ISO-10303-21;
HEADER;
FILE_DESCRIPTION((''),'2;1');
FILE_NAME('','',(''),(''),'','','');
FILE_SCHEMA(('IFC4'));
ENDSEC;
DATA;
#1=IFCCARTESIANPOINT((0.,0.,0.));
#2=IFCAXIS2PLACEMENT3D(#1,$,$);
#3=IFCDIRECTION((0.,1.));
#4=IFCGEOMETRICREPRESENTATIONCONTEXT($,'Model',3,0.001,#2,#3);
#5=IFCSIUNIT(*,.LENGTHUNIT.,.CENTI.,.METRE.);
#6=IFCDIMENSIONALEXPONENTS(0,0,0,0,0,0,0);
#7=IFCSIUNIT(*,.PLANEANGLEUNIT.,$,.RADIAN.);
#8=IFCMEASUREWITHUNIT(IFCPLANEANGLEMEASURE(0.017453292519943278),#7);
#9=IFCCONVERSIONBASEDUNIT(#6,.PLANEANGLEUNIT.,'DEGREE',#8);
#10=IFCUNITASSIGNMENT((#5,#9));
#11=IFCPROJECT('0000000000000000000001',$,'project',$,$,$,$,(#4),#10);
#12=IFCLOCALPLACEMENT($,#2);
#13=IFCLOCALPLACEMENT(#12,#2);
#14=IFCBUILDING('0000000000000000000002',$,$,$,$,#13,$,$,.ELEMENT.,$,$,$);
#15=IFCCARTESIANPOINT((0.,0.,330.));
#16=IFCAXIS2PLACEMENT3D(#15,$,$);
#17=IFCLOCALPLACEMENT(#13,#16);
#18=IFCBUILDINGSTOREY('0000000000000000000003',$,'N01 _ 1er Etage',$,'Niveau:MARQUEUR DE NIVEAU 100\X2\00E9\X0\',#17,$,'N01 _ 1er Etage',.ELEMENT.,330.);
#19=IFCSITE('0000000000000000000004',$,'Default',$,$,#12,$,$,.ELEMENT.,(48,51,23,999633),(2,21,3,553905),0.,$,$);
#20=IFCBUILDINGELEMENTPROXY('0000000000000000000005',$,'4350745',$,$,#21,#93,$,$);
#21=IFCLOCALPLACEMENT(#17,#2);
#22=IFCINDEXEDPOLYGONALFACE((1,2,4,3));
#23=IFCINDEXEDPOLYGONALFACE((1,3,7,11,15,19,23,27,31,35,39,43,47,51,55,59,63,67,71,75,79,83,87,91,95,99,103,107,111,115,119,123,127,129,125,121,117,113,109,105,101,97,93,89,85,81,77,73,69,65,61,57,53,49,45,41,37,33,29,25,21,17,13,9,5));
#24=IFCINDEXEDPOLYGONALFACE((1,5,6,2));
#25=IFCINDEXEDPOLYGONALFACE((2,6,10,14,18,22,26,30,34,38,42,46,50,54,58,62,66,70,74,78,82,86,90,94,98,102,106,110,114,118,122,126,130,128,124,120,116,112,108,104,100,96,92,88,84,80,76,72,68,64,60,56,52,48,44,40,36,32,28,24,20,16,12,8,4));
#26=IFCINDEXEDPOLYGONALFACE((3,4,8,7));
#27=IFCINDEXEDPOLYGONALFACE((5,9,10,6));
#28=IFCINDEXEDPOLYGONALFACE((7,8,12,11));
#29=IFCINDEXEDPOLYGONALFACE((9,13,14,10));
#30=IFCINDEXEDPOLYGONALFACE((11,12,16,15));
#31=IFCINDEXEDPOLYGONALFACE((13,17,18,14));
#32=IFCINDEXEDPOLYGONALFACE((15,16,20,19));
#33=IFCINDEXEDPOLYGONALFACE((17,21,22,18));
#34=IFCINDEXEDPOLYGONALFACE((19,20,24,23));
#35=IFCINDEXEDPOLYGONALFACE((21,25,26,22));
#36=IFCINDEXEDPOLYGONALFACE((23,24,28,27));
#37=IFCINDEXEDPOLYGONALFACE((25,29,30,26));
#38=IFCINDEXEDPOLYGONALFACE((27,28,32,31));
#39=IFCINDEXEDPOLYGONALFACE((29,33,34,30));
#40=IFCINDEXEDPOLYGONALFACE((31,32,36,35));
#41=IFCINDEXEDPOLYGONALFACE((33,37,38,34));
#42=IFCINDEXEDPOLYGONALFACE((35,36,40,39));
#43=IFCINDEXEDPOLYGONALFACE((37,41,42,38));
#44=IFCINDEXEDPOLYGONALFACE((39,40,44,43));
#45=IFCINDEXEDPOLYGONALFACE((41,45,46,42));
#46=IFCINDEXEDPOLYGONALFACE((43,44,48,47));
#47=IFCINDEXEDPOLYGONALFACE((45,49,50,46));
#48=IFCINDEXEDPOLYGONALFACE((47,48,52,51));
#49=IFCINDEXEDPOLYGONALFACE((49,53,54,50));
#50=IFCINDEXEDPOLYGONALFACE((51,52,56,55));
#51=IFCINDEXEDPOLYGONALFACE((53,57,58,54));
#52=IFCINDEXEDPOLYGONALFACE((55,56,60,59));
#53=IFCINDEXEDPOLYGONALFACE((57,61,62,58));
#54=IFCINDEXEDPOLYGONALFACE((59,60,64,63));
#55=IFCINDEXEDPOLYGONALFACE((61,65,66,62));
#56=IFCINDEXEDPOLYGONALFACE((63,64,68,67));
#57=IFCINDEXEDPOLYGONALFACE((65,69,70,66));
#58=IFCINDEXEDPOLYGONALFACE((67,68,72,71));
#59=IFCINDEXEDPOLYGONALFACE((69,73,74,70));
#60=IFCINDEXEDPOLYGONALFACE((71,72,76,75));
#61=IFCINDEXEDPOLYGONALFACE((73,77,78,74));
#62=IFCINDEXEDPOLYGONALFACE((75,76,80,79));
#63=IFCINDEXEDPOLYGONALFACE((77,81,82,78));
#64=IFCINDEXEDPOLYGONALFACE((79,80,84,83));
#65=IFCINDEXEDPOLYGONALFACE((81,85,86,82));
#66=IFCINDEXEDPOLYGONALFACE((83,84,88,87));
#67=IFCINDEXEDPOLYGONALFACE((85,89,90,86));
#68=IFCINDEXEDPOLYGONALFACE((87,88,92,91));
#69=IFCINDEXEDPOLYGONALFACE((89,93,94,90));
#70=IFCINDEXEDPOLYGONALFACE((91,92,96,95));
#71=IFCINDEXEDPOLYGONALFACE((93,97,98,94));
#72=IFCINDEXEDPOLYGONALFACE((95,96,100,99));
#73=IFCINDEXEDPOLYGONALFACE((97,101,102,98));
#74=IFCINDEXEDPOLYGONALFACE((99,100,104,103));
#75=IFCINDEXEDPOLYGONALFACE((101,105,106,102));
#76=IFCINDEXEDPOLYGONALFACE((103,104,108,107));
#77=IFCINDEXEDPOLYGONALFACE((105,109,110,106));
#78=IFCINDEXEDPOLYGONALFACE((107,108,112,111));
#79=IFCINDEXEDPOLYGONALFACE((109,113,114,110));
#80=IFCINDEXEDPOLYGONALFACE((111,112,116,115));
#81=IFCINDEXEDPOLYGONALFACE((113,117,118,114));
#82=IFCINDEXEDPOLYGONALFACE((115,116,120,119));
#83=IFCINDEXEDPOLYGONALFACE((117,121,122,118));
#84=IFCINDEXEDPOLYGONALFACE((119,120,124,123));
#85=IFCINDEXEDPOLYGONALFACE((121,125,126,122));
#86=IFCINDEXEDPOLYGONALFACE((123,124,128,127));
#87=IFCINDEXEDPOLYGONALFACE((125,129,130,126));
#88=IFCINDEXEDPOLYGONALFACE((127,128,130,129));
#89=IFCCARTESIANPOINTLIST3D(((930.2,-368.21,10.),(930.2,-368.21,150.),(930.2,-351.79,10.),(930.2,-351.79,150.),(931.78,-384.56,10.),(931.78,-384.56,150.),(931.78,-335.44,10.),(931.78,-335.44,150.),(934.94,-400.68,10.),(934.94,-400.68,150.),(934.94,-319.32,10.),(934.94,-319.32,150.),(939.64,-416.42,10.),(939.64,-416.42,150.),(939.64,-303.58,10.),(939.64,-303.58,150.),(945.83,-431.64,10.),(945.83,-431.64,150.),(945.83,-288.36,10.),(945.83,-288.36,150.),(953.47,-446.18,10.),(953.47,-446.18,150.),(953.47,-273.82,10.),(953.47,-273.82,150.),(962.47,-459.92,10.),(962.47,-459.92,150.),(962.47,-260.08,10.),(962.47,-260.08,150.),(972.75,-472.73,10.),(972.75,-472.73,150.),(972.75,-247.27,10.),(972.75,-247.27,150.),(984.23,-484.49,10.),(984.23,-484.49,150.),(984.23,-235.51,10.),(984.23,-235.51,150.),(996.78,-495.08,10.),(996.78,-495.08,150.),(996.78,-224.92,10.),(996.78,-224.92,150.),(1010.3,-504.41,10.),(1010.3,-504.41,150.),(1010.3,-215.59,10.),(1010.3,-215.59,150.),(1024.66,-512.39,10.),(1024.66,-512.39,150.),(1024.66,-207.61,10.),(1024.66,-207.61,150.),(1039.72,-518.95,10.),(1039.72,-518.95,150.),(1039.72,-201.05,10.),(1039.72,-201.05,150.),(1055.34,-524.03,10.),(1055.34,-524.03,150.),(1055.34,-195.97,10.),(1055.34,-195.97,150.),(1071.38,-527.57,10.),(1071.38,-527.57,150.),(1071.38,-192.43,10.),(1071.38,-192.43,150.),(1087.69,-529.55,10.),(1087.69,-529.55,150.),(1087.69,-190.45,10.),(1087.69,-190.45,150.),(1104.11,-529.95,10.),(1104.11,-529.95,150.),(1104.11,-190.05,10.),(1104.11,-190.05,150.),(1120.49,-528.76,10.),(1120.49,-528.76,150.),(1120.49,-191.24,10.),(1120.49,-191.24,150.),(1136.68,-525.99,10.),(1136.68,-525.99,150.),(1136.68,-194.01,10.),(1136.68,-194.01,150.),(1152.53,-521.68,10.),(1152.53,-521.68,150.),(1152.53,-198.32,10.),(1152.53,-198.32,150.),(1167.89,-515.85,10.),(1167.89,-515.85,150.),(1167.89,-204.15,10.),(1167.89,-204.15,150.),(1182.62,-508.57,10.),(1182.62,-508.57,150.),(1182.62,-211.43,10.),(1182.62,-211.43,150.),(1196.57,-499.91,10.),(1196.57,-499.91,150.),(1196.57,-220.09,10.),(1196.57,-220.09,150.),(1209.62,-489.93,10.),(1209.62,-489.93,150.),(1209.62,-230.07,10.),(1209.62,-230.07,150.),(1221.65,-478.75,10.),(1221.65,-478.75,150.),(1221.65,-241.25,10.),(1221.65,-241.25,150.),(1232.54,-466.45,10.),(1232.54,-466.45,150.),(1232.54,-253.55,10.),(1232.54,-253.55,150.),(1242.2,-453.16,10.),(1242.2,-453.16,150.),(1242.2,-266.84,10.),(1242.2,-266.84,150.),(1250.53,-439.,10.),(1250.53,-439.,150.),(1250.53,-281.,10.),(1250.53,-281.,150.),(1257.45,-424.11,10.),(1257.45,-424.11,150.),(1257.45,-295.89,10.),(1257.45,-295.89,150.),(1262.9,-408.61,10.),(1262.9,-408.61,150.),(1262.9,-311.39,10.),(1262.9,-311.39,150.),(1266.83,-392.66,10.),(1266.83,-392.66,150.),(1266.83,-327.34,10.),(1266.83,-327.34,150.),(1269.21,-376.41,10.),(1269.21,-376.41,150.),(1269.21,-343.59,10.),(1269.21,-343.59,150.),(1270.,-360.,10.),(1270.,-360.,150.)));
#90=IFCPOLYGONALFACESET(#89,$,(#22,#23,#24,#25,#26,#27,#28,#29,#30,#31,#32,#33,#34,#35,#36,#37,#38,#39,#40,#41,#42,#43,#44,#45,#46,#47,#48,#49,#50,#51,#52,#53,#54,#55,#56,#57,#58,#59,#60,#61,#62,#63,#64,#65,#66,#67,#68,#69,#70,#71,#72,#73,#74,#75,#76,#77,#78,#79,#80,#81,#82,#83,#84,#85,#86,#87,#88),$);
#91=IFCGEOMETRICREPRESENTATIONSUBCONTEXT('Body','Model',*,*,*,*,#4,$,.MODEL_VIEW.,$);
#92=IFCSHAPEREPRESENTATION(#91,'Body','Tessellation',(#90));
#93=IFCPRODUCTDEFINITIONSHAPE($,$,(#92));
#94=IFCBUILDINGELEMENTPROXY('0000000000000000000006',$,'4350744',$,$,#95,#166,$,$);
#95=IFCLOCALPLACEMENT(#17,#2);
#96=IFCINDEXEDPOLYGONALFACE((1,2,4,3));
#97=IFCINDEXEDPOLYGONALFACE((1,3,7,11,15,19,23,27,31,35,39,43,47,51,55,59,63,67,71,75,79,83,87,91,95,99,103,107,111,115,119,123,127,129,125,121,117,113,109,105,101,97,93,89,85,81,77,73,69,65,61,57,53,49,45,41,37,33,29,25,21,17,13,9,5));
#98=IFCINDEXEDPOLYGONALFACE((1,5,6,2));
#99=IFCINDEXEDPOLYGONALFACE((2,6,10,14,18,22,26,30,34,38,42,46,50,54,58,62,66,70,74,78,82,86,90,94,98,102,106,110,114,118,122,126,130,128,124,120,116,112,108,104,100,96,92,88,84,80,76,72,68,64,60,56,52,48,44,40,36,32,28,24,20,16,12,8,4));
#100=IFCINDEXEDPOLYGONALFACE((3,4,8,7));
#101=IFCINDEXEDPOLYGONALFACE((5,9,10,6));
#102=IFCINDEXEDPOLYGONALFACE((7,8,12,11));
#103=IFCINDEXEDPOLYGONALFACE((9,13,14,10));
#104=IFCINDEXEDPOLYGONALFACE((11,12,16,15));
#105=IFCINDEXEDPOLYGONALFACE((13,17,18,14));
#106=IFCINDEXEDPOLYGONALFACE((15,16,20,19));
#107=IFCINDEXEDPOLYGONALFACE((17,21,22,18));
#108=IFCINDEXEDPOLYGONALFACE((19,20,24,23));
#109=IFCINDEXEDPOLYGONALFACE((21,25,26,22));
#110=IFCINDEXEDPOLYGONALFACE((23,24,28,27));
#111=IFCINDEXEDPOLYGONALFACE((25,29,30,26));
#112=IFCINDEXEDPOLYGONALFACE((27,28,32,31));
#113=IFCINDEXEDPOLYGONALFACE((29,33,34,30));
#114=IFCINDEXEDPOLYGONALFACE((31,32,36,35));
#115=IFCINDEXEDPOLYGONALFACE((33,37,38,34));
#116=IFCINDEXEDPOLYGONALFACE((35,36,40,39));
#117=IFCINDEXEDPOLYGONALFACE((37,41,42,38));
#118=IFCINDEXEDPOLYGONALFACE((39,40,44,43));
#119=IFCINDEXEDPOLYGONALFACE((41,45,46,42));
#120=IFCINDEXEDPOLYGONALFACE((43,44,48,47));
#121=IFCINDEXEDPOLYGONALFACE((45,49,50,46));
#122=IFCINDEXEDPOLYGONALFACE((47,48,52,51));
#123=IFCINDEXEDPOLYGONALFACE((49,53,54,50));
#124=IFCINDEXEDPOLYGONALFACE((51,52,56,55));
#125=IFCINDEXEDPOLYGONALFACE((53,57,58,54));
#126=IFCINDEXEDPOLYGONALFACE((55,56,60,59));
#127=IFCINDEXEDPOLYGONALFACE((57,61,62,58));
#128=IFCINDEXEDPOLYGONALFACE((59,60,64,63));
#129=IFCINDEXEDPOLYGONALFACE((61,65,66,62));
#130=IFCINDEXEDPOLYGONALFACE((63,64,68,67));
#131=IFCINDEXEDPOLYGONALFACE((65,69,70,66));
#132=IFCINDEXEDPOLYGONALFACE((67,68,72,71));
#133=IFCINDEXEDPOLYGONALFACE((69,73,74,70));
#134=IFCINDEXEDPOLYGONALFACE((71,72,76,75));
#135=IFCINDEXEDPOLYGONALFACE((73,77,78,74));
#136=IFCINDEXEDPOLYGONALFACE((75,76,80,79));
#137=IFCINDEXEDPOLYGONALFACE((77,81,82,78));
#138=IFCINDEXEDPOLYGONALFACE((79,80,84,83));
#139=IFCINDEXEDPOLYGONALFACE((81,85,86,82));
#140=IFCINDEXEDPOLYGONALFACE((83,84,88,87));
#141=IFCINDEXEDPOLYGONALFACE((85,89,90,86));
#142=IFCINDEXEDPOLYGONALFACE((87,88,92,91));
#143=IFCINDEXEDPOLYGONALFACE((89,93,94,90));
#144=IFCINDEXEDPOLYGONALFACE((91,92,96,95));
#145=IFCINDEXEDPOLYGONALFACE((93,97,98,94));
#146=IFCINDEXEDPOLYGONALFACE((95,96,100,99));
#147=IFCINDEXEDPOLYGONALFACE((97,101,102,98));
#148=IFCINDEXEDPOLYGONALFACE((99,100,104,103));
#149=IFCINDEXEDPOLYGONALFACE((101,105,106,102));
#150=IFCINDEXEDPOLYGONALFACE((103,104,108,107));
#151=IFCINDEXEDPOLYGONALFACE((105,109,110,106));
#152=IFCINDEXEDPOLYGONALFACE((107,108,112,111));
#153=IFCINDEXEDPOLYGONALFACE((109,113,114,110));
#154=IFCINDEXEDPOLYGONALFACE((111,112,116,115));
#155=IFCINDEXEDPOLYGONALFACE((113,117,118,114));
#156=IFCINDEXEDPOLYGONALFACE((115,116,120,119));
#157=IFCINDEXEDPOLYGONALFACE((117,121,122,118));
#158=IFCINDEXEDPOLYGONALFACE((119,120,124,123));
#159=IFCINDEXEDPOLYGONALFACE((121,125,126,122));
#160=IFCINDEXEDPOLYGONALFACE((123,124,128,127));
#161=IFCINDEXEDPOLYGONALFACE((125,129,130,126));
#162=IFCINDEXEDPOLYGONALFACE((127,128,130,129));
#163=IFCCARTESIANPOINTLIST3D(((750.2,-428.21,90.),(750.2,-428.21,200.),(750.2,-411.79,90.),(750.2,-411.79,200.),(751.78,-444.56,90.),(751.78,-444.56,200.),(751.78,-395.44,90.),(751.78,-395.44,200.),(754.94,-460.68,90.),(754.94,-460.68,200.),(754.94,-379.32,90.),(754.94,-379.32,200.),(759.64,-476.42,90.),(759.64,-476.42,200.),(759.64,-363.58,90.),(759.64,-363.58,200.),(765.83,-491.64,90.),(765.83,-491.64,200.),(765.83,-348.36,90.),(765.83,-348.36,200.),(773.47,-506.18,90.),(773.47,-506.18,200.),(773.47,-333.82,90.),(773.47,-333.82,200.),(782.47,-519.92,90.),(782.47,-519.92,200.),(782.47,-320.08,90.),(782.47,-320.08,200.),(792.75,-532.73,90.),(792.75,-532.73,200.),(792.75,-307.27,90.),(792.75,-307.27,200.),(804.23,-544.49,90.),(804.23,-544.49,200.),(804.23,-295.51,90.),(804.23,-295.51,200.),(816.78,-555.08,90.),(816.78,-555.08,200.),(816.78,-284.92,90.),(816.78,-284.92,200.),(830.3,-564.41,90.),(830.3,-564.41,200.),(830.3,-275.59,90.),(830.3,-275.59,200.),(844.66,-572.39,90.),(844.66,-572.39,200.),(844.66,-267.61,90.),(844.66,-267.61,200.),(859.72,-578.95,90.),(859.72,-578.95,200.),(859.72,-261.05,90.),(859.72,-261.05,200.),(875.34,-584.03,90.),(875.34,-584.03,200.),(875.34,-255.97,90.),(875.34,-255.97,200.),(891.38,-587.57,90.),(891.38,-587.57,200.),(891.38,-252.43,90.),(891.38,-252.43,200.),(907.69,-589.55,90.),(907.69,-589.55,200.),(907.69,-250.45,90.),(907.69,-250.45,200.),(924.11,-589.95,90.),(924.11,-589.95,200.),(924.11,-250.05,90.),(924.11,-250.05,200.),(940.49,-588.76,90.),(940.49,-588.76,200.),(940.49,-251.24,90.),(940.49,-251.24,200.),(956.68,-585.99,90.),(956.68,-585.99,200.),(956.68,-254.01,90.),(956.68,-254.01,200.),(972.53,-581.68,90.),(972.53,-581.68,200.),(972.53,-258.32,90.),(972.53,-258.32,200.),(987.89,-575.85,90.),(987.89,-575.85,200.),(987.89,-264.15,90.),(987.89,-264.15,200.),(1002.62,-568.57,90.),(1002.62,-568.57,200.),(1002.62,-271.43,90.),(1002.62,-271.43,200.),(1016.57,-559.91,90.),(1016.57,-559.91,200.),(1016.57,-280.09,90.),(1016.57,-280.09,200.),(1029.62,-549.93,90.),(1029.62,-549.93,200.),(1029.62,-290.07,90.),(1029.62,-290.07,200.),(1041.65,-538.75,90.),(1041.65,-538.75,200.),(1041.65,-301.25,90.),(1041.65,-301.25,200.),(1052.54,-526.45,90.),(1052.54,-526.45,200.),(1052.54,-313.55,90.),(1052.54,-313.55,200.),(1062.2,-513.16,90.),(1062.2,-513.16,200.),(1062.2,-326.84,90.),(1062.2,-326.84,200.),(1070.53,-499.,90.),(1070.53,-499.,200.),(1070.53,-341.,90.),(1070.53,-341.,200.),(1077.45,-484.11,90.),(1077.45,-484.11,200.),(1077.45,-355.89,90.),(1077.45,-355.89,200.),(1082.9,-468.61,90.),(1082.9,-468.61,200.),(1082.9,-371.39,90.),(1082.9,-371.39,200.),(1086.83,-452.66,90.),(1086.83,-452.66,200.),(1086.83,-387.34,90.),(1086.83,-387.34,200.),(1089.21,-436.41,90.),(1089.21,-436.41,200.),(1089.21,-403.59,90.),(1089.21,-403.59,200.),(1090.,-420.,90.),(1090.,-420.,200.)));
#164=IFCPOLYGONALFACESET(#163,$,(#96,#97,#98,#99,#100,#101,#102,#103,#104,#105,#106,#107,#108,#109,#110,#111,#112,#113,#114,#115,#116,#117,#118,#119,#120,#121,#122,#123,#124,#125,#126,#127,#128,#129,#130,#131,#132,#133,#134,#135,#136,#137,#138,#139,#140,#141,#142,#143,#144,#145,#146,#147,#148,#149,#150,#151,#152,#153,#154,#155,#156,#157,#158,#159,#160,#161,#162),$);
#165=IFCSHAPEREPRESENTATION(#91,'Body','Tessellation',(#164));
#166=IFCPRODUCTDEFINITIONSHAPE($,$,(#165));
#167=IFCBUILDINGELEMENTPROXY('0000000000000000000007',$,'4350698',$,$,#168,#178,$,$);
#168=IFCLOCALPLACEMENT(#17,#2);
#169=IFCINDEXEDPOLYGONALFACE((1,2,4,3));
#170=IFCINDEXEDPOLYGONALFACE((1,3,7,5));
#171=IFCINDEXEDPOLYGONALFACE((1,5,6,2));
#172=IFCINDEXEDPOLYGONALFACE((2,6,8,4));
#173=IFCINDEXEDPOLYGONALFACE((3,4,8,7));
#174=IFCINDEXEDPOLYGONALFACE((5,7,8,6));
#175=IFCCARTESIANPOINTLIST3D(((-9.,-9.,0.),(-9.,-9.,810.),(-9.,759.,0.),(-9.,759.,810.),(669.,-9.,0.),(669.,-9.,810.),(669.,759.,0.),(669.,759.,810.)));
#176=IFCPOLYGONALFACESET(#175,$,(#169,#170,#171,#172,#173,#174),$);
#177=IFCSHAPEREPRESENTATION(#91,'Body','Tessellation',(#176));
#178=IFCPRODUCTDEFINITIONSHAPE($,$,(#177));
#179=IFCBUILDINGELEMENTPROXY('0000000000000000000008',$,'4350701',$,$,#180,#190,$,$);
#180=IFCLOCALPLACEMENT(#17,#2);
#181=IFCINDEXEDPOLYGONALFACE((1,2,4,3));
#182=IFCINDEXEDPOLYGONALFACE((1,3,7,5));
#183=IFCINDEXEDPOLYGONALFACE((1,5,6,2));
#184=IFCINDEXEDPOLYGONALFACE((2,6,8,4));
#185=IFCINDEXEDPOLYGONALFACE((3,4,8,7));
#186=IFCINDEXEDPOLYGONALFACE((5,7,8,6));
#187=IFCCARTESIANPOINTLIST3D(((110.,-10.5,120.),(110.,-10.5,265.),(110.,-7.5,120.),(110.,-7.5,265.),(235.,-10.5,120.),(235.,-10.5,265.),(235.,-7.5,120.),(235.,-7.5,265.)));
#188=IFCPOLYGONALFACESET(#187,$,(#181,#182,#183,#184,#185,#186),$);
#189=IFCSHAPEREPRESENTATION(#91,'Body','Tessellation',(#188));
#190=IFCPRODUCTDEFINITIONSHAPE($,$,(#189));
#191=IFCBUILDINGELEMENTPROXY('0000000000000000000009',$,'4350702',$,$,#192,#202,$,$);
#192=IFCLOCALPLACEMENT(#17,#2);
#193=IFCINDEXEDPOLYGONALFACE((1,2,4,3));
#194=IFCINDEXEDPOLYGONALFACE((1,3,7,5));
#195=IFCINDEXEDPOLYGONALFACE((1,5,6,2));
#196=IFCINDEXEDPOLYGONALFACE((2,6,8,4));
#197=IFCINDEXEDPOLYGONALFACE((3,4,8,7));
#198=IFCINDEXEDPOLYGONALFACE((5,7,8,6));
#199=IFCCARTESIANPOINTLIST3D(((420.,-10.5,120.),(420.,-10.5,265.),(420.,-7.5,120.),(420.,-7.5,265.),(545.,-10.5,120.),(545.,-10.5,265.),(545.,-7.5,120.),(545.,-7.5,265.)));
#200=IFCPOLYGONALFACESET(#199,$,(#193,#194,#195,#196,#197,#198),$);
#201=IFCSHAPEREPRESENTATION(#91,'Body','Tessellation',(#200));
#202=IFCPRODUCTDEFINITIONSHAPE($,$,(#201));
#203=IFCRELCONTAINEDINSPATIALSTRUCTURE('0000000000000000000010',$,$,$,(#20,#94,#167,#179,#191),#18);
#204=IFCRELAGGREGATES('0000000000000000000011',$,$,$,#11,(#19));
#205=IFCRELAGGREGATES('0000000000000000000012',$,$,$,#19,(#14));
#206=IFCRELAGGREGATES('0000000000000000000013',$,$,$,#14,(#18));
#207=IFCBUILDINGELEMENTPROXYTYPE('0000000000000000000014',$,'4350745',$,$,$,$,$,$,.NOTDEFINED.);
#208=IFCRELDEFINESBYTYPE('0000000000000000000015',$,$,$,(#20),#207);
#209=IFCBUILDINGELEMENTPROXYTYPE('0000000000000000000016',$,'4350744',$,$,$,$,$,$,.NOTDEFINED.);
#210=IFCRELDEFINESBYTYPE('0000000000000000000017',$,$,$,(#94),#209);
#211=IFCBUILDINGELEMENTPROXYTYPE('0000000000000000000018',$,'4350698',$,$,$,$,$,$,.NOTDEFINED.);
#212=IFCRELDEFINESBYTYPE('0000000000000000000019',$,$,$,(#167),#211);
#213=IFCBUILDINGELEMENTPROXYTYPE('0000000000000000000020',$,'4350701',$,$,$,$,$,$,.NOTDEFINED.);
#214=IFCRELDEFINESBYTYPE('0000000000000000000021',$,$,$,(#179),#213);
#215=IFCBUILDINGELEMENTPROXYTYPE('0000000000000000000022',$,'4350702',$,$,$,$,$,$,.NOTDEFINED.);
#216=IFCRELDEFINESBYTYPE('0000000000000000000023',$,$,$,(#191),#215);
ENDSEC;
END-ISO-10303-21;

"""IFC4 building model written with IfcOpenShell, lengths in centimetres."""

from ifc_helpers import new_model, entity, si_unit, converted_unit, direction, frame, frame_2d, origin, origin_2d_with_axis, place, context, subcontext, project, spatial, rectangle, circle, extrude, type_object, element, save


model = new_model("IFC4")

# Units and contexts
model_context = context("Model", 3, precision=0.001, world=origin(), true_north=direction((0.0, 1.0)))
body_context = subcontext(model_context, "Body", "Model", "MODEL_VIEW")
ifc_project = project(units=[si_unit("LENGTHUNIT", "METRE", prefix="CENTI"), converted_unit("PLANEANGLEUNIT", "DEGREE", entity("IfcPlaneAngleMeasure", 0.017453292519943278), si_unit("PLANEANGLEUNIT", "RADIAN"), dimensions=[0, 0, 0, 0, 0, 0, 0])], contexts=[model_context])

# Site, building, storey
site_placement = place(None, origin())
site = spatial("IfcSite", under=ifc_project, at=site_placement, Name="Default", CompositionType="ELEMENT", RefLatitude=(48, 51, 23, 999633), RefLongitude=(2, 21, 3, 553905), RefElevation=0.0)
building_placement = place(site_placement, origin())
building = spatial("IfcBuilding", under=site, at=building_placement, CompositionType="ELEMENT")
storey_placement = place(building_placement, frame((0.0, 0.0, 330.0)))
storey = spatial("IfcBuildingStorey", under=building, at=storey_placement, Name="N01 _ 1er Etage", ObjectType="Niveau:MARQUEUR DE NIVEAU 100é", LongName="N01 _ 1er Etage", CompositionType="ELEMENT", Elevation=330.0)

# Building element proxies
building_element_proxy_type_1 = type_object("IfcBuildingElementProxyType", Name="4350745", PredefinedType="NOTDEFINED")
proxy_1_placement = place(storey_placement, origin())
element("IfcBuildingElementProxy", 1, at=proxy_1_placement, inside=storey, type_object=building_element_proxy_type_1, Name="4350745", context=body_context, shape_type="SweptSolid", body=[
    extrude(circle(Radius=170.0, at=origin_2d_with_axis()), frame((1100.0, -360.0, 10.0)), (0.0, 0.0, 1.0), 140.0),
])
building_element_proxy_type_2 = type_object("IfcBuildingElementProxyType", Name="4350744", PredefinedType="NOTDEFINED")
proxy_2_placement = place(storey_placement, origin())
element("IfcBuildingElementProxy", 2, at=proxy_2_placement, inside=storey, type_object=building_element_proxy_type_2, Name="4350744", context=body_context, shape_type="SweptSolid", body=[
    extrude(circle(Radius=170.0, at=origin_2d_with_axis()), frame((920.0, -420.0, 90.0)), (0.0, 0.0, 1.0), 110.0),
])
building_element_proxy_type_3 = type_object("IfcBuildingElementProxyType", Name="4350698", PredefinedType="NOTDEFINED")
proxy_3_placement = place(storey_placement, origin())
element("IfcBuildingElementProxy", 3, at=proxy_3_placement, inside=storey, type_object=building_element_proxy_type_3, Name="4350698", context=body_context, shape_type="SweptSolid", body=[
    extrude(rectangle(XDim=678.0, YDim=768.0, at=origin_2d_with_axis()), frame((330.0, 375.0, 0.0)), (0.0, 0.0, 1.0), 810.0),
])
building_element_proxy_type_4 = type_object("IfcBuildingElementProxyType", Name="4350701", PredefinedType="NOTDEFINED")
proxy_4_placement = place(storey_placement, origin())
element("IfcBuildingElementProxy", 4, at=proxy_4_placement, inside=storey, type_object=building_element_proxy_type_4, Name="4350701", context=body_context, shape_type="SweptSolid", body=[
    extrude(rectangle(XDim=125.0, YDim=3.0, at=frame_2d((0.0, 0.0), x_axis=(1.0, 0.0))), frame((172.5, -9.0, 120.0)), (0.0, 0.0, 1.0), 145.0),
])
building_element_proxy_type_5 = type_object("IfcBuildingElementProxyType", Name="4350702", PredefinedType="NOTDEFINED")
proxy_5_placement = place(storey_placement, origin())
element("IfcBuildingElementProxy", 5, at=proxy_5_placement, inside=storey, type_object=building_element_proxy_type_5, Name="4350702", context=body_context, shape_type="SweptSolid", body=[
    extrude(rectangle(XDim=125.0, YDim=3.0, at=frame_2d((0.0, 0.0), x_axis=(1.0, 0.0))), frame((482.5, -9.0, 120.0)), (0.0, 0.0, 1.0), 145.0),
])

save(model, "model.ifc")
